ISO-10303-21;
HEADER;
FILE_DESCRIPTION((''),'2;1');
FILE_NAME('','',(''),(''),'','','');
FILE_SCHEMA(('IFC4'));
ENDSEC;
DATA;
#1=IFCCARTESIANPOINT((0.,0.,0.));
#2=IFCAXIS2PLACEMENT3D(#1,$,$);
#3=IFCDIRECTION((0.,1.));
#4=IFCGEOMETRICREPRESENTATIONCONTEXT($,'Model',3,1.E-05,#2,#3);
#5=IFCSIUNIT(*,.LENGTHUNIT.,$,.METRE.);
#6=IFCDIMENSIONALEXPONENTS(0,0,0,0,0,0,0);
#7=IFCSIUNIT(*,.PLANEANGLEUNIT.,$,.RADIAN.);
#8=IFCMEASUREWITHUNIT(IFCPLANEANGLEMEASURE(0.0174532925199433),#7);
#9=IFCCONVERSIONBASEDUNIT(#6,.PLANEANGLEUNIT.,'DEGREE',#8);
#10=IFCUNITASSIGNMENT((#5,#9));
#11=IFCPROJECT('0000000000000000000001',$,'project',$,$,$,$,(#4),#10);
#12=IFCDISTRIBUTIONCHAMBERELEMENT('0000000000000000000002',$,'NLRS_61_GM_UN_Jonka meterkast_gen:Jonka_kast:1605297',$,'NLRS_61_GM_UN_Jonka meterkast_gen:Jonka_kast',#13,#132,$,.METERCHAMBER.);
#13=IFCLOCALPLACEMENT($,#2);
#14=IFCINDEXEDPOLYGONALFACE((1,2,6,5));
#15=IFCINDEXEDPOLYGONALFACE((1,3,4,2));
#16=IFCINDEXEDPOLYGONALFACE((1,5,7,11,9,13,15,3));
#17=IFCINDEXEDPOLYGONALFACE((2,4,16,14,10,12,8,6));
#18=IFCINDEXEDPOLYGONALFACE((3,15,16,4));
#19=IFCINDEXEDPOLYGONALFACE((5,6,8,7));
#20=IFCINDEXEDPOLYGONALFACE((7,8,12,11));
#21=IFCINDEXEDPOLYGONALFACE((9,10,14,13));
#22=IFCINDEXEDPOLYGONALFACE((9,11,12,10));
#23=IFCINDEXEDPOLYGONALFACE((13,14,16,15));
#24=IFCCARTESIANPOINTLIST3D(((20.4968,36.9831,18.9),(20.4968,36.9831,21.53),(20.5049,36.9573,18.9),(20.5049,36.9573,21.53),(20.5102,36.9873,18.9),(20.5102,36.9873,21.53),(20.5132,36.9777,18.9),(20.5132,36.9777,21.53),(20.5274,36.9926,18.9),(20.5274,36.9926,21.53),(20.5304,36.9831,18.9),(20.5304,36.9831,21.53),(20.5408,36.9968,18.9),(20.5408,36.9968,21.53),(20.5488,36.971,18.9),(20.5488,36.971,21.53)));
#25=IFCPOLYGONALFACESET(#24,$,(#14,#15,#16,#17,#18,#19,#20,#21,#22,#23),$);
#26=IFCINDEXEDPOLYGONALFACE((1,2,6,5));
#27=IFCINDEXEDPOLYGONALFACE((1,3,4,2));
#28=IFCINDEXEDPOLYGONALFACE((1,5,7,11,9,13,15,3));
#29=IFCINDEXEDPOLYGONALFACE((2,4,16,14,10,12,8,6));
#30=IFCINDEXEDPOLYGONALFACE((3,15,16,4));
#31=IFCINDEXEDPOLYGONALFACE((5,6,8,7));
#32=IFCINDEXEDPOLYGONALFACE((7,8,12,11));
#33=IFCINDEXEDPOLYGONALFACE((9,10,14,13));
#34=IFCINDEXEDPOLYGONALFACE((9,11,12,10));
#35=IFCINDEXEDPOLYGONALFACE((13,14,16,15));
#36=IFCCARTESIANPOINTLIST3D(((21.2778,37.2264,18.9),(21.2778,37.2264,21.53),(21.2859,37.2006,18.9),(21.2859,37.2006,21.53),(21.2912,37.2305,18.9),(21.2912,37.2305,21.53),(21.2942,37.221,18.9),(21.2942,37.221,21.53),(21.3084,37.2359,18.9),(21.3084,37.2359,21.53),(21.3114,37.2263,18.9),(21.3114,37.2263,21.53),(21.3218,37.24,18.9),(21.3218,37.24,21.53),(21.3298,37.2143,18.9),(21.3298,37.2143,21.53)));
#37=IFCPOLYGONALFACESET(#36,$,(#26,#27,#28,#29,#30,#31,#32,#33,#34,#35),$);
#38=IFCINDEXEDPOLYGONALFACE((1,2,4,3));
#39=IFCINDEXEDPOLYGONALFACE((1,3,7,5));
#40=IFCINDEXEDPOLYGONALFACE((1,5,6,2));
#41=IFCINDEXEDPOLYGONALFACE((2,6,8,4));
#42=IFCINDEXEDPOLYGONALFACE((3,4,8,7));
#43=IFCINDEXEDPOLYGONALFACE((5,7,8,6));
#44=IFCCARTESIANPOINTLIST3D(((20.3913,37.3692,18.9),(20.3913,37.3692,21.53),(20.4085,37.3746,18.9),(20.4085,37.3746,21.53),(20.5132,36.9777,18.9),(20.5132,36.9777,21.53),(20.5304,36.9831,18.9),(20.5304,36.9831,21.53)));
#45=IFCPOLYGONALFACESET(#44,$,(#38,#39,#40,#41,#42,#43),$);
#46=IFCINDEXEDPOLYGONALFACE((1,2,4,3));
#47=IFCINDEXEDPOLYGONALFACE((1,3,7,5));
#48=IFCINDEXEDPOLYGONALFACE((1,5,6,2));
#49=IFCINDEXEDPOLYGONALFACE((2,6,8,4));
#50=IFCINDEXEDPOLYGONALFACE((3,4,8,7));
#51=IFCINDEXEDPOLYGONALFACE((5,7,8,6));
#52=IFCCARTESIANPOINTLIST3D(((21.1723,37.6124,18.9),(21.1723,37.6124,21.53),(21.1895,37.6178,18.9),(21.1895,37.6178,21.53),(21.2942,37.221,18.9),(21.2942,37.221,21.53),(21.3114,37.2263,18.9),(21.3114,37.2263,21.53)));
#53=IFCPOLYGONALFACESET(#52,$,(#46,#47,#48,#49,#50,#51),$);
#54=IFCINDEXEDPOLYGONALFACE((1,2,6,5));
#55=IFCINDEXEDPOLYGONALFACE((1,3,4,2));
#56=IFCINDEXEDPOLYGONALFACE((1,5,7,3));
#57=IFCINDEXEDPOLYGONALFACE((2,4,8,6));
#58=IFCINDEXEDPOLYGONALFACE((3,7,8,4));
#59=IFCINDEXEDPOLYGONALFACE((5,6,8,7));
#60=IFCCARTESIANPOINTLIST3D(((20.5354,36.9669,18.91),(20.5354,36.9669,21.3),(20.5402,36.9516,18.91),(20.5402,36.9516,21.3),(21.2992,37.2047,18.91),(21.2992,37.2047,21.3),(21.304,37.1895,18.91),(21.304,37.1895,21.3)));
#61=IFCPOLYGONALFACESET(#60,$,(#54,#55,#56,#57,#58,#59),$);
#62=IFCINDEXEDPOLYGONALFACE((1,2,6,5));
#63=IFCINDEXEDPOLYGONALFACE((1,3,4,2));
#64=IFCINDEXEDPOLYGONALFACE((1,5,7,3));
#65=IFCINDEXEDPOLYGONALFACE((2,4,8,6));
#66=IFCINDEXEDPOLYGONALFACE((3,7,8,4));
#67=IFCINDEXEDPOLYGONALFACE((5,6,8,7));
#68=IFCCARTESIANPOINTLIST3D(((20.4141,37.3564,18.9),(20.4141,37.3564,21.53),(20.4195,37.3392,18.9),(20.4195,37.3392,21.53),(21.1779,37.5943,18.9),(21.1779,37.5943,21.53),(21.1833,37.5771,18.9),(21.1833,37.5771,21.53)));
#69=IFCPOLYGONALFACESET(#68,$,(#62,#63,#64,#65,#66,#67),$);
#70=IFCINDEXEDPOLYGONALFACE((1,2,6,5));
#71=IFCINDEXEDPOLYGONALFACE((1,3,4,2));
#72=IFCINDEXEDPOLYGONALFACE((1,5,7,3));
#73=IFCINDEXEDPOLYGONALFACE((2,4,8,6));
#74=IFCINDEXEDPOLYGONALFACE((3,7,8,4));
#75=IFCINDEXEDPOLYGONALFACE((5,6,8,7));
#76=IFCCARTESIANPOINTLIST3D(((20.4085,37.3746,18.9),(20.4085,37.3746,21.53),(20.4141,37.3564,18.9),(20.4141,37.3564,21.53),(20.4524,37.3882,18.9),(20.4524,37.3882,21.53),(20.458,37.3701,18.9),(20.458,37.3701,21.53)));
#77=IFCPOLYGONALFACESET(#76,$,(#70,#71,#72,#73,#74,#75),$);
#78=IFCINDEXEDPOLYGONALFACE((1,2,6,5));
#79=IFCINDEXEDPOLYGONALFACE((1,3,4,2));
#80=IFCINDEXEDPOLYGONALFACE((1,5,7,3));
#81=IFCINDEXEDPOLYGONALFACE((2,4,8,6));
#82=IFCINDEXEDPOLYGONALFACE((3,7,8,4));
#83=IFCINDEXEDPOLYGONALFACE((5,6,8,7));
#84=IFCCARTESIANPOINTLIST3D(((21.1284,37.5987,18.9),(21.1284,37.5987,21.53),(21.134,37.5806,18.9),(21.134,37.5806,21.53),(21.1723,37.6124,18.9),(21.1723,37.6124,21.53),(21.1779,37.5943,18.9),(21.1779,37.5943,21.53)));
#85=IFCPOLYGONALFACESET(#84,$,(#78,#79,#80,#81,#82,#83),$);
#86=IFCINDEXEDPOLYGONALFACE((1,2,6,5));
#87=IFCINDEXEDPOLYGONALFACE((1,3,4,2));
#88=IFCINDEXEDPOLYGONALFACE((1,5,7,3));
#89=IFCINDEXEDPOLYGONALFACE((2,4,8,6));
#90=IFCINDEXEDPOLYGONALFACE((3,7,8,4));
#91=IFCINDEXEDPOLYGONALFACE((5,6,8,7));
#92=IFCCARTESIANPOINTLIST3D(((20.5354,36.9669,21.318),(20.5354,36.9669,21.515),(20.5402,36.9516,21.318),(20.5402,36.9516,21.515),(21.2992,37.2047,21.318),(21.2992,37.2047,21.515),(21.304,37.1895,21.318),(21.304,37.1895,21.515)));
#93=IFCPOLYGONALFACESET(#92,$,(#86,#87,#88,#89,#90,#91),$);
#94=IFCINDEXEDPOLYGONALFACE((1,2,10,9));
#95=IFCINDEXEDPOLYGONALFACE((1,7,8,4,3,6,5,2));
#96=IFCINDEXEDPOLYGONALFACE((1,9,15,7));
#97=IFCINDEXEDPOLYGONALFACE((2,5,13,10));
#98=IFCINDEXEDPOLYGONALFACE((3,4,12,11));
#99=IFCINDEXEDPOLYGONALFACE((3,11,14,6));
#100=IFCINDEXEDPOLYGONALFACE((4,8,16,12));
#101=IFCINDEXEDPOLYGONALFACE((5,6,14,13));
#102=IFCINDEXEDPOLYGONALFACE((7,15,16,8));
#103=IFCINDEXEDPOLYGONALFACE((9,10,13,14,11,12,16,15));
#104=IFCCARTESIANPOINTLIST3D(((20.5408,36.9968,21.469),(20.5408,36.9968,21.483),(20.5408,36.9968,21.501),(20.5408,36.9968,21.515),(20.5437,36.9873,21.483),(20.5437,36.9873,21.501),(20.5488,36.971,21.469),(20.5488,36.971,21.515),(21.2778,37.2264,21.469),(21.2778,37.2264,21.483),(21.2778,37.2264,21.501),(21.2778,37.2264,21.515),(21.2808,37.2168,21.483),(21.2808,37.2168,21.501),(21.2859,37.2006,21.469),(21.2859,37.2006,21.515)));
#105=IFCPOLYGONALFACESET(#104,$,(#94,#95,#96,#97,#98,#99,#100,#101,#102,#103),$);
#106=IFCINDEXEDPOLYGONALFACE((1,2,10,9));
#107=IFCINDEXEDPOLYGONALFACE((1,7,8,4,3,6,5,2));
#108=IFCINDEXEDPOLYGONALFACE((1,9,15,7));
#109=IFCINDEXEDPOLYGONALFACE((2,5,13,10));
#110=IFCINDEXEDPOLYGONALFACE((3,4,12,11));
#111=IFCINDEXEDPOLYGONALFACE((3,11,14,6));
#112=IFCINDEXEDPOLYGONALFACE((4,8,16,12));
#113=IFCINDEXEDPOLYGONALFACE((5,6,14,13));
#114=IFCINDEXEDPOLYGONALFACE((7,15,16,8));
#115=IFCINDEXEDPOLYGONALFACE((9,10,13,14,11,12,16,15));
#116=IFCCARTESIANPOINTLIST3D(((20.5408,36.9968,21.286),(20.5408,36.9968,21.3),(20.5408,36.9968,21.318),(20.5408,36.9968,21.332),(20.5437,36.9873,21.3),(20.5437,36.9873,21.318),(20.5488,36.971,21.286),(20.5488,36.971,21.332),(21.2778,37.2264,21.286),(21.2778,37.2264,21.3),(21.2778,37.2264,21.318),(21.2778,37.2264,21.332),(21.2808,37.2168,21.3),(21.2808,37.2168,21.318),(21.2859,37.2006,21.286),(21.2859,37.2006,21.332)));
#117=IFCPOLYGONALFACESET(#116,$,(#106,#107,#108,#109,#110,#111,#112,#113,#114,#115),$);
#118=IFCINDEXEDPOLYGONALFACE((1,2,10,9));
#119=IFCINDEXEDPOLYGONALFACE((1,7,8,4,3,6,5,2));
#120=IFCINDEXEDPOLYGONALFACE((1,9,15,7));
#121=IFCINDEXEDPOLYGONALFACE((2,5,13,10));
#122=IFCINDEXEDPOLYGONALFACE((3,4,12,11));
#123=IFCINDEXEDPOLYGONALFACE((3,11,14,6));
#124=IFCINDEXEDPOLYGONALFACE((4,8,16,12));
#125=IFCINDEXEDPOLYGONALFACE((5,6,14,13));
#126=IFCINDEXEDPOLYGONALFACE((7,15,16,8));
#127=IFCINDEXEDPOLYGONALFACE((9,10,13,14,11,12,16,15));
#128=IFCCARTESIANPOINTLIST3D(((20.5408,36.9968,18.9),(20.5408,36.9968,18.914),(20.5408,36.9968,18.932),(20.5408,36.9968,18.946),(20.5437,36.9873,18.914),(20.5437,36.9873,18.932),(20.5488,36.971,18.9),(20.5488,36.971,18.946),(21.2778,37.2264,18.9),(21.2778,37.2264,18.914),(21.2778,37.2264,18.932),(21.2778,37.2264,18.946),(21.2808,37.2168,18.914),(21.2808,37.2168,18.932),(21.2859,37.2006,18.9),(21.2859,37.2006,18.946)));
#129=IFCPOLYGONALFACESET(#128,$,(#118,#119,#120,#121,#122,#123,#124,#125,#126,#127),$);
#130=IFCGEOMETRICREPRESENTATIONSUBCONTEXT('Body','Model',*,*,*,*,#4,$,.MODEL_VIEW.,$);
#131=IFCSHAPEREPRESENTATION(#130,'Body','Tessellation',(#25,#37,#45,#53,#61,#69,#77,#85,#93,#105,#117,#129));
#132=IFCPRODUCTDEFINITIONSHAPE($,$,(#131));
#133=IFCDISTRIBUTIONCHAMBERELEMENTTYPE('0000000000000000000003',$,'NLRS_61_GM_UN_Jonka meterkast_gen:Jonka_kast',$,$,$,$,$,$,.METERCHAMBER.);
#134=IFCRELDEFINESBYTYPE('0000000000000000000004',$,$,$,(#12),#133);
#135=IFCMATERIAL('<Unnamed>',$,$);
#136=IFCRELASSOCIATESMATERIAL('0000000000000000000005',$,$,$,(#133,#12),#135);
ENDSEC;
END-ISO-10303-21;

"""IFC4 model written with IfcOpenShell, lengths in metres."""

from ifc_helpers import new_model, entity, si_unit, converted_unit, direction, frame, origin, place, context, subcontext, project, indexed_curve, outline, extrude, source, transform, mapped, material, type_object, type_shapes, element, save


model = new_model("IFC4")

# Units and contexts
model_context = context("Model", 3, precision=1e-05, world=origin(), true_north=direction((0.0, 1.0)))
body_context = subcontext(model_context, "Body", "Model", "MODEL_VIEW")
ifc_project = project(units=[si_unit("LENGTHUNIT", "METRE"), converted_unit("PLANEANGLEUNIT", "DEGREE", entity("IfcPlaneAngleMeasure", 0.0174532925199433), si_unit("PLANEANGLEUNIT", "RADIAN"), dimensions=[0, 0, 0, 0, 0, 0, 0])], contexts=[model_context])

# Distribution chamber element
ifc_material = material(Name="<Unnamed>")
distribution_chamber_element_type = type_object("IfcDistributionChamberElementType", Name="NLRS_61_GM_UN_Jonka meterkast_gen:Jonka_kast", PredefinedType="METERCHAMBER", material=ifc_material)
shared_shape_1 = source(origin(), body_context, "Body", "SweptSolid", [
    extrude(outline(indexed_curve([(-0.0093, -0.023), (0.0178, -0.023), (0.0178, 0.023), (-0.0093, 0.023), (-0.0093, 0.009), (0.0007, 0.009), (0.0007, -0.009), (-0.0093, -0.009), (-0.0093, -0.023)], self_intersect=False)), frame((-0.409, -0.4092, 0.0), z_axis=(0.0, 0.0, 1.0), x_axis=(0.0, -1.0, 0.0)), (0.0, 0.0, 1.0), 2.63),
    extrude(outline(indexed_curve([(-0.0093, -0.023), (0.0178, -0.023), (0.0178, 0.023), (-0.0093, 0.023), (-0.0093, 0.009), (0.0007, 0.009), (0.0007, -0.009), (-0.0093, -0.009), (-0.0093, -0.023)], self_intersect=False)), frame((0.409, -0.4092, 0.0), z_axis=(0.0, 0.0, 1.0), x_axis=(0.0, -1.0, 0.0)), (0.0, 0.0, 1.0), 2.63),
    extrude(outline(indexed_curve([(-0.205, -0.009), (0.205, -0.009), (0.205, 0.009), (-0.205, 0.009), (-0.205, -0.009)], self_intersect=False)), frame((-0.409, -0.205, 0.0), z_axis=(0.0, 0.0, 1.0), x_axis=(0.0, -1.0, 0.0)), (0.0, 0.0, 1.0), 2.63),
    extrude(outline(indexed_curve([(-0.205, -0.009), (0.205, -0.009), (0.205, 0.009), (-0.205, 0.009), (-0.205, -0.009)], self_intersect=False)), frame((0.409, -0.205, 0.0), z_axis=(0.0, 0.0, 1.0), x_axis=(0.0, -1.0, 0.0)), (0.0, 0.0, 1.0), 2.63),
    extrude(outline(indexed_curve([(-0.4, -0.008), (0.4, -0.008), (0.4, 0.008), (-0.4, 0.008), (-0.4, -0.008)], self_intersect=False)), frame((0.0, -0.435, 0.01), z_axis=(0.0, 0.0, 1.0), x_axis=(-1.0, 0.0, 0.0)), (0.0, 0.0, 1.0), 2.39),
    extrude(outline(indexed_curve([(-0.4, -0.009), (0.4, -0.009), (0.4, 0.009), (-0.4, 0.009), (-0.4, -0.009)], self_intersect=False)), frame((0.0, -0.028, 0.0), z_axis=(0.0, 0.0, 1.0), x_axis=(-1.0, 0.0, 0.0)), (0.0, 0.0, 1.0), 2.63),
    extrude(outline(indexed_curve([(-0.023, -0.0095), (0.023, -0.0095), (0.023, 0.0095), (-0.023, 0.0095), (-0.023, -0.0095)], self_intersect=False)), frame((-0.377, -0.0095, 0.0), z_axis=(0.0, 0.0, 1.0), x_axis=(-1.0, 0.0, 0.0)), (0.0, 0.0, 1.0), 2.63),
    extrude(outline(indexed_curve([(-0.023, -0.0095), (0.023, -0.0095), (0.023, 0.0095), (-0.023, 0.0095), (-0.023, -0.0095)], self_intersect=False)), frame((0.377, -0.0095, 0.0), z_axis=(0.0, 0.0, 1.0), x_axis=(-1.0, 0.0, 0.0)), (0.0, 0.0, 1.0), 2.63),
    extrude(outline(indexed_curve([(-0.4, -0.008), (0.4, -0.008), (0.4, 0.008), (-0.4, 0.008), (-0.4, -0.008)], self_intersect=False)), frame((0.0, -0.435, 2.418), z_axis=(0.0, 0.0, 1.0), x_axis=(-1.0, 0.0, 0.0)), (0.0, 0.0, 1.0), 0.197),
    extrude(outline(indexed_curve([(-0.023, -0.0178), (0.023, -0.0178), (0.023, 0.0093), (0.009, 0.0093), (0.009, -0.0007), (-0.009, -0.0007), (-0.009, 0.0093), (-0.023, 0.0093), (-0.023, -0.0178)], self_intersect=False)), frame((-0.386, -0.4092, 2.592), z_axis=(1.0, 0.0, 0.0), x_axis=(0.0, 0.0, -1.0)), (0.0, 0.0, 1.0), 0.772),
    extrude(outline(indexed_curve([(-0.023, -0.0178), (0.023, -0.0178), (0.023, 0.0093), (0.009, 0.0093), (0.009, -0.0007), (-0.009, -0.0007), (-0.009, 0.0093), (-0.023, 0.0093), (-0.023, -0.0178)], self_intersect=False)), frame((-0.386, -0.4092, 2.409), z_axis=(1.0, 0.0, 0.0), x_axis=(0.0, 0.0, -1.0)), (0.0, 0.0, 1.0), 0.772),
    extrude(outline(indexed_curve([(-0.023, -0.0178), (0.023, -0.0178), (0.023, 0.0093), (0.009, 0.0093), (0.009, -0.0007), (-0.009, -0.0007), (-0.009, 0.0093), (-0.023, 0.0093), (-0.023, -0.0178)], self_intersect=False)), frame((-0.386, -0.4092, 0.023), z_axis=(1.0, 0.0, 0.0), x_axis=(0.0, 0.0, -1.0)), (0.0, 0.0, 1.0), 0.772),
])
type_shapes(distribution_chamber_element_type, [shared_shape_1])
placement_1 = place(None, frame((13.1348, 11.9886, 0.0), z_axis=(0.0, 0.0, 1.0), x_axis=(0.954771, 0.297342, 0.0)))
placement_2 = place(placement_1, origin())
placement_3 = place(placement_2, frame((0.0, 0.0, 18.9)))
placement_4 = place(placement_3, origin())
distribution_chamber_element_1_placement = place(placement_4, frame((14.893, 22.075, 0.0)))
element("IfcDistributionChamberElement", 1, at=distribution_chamber_element_1_placement, type_object=distribution_chamber_element_type, material=ifc_material, Name="NLRS_61_GM_UN_Jonka meterkast_gen:Jonka_kast:1605297", ObjectType="NLRS_61_GM_UN_Jonka meterkast_gen:Jonka_kast", PredefinedType="METERCHAMBER", context=body_context, shape_type="MappedRepresentation", body=[
    mapped(shared_shape_1, transform((0.0, 0.0, 0.0), scale=1.0)),
])

save(model, "model.ifc")
